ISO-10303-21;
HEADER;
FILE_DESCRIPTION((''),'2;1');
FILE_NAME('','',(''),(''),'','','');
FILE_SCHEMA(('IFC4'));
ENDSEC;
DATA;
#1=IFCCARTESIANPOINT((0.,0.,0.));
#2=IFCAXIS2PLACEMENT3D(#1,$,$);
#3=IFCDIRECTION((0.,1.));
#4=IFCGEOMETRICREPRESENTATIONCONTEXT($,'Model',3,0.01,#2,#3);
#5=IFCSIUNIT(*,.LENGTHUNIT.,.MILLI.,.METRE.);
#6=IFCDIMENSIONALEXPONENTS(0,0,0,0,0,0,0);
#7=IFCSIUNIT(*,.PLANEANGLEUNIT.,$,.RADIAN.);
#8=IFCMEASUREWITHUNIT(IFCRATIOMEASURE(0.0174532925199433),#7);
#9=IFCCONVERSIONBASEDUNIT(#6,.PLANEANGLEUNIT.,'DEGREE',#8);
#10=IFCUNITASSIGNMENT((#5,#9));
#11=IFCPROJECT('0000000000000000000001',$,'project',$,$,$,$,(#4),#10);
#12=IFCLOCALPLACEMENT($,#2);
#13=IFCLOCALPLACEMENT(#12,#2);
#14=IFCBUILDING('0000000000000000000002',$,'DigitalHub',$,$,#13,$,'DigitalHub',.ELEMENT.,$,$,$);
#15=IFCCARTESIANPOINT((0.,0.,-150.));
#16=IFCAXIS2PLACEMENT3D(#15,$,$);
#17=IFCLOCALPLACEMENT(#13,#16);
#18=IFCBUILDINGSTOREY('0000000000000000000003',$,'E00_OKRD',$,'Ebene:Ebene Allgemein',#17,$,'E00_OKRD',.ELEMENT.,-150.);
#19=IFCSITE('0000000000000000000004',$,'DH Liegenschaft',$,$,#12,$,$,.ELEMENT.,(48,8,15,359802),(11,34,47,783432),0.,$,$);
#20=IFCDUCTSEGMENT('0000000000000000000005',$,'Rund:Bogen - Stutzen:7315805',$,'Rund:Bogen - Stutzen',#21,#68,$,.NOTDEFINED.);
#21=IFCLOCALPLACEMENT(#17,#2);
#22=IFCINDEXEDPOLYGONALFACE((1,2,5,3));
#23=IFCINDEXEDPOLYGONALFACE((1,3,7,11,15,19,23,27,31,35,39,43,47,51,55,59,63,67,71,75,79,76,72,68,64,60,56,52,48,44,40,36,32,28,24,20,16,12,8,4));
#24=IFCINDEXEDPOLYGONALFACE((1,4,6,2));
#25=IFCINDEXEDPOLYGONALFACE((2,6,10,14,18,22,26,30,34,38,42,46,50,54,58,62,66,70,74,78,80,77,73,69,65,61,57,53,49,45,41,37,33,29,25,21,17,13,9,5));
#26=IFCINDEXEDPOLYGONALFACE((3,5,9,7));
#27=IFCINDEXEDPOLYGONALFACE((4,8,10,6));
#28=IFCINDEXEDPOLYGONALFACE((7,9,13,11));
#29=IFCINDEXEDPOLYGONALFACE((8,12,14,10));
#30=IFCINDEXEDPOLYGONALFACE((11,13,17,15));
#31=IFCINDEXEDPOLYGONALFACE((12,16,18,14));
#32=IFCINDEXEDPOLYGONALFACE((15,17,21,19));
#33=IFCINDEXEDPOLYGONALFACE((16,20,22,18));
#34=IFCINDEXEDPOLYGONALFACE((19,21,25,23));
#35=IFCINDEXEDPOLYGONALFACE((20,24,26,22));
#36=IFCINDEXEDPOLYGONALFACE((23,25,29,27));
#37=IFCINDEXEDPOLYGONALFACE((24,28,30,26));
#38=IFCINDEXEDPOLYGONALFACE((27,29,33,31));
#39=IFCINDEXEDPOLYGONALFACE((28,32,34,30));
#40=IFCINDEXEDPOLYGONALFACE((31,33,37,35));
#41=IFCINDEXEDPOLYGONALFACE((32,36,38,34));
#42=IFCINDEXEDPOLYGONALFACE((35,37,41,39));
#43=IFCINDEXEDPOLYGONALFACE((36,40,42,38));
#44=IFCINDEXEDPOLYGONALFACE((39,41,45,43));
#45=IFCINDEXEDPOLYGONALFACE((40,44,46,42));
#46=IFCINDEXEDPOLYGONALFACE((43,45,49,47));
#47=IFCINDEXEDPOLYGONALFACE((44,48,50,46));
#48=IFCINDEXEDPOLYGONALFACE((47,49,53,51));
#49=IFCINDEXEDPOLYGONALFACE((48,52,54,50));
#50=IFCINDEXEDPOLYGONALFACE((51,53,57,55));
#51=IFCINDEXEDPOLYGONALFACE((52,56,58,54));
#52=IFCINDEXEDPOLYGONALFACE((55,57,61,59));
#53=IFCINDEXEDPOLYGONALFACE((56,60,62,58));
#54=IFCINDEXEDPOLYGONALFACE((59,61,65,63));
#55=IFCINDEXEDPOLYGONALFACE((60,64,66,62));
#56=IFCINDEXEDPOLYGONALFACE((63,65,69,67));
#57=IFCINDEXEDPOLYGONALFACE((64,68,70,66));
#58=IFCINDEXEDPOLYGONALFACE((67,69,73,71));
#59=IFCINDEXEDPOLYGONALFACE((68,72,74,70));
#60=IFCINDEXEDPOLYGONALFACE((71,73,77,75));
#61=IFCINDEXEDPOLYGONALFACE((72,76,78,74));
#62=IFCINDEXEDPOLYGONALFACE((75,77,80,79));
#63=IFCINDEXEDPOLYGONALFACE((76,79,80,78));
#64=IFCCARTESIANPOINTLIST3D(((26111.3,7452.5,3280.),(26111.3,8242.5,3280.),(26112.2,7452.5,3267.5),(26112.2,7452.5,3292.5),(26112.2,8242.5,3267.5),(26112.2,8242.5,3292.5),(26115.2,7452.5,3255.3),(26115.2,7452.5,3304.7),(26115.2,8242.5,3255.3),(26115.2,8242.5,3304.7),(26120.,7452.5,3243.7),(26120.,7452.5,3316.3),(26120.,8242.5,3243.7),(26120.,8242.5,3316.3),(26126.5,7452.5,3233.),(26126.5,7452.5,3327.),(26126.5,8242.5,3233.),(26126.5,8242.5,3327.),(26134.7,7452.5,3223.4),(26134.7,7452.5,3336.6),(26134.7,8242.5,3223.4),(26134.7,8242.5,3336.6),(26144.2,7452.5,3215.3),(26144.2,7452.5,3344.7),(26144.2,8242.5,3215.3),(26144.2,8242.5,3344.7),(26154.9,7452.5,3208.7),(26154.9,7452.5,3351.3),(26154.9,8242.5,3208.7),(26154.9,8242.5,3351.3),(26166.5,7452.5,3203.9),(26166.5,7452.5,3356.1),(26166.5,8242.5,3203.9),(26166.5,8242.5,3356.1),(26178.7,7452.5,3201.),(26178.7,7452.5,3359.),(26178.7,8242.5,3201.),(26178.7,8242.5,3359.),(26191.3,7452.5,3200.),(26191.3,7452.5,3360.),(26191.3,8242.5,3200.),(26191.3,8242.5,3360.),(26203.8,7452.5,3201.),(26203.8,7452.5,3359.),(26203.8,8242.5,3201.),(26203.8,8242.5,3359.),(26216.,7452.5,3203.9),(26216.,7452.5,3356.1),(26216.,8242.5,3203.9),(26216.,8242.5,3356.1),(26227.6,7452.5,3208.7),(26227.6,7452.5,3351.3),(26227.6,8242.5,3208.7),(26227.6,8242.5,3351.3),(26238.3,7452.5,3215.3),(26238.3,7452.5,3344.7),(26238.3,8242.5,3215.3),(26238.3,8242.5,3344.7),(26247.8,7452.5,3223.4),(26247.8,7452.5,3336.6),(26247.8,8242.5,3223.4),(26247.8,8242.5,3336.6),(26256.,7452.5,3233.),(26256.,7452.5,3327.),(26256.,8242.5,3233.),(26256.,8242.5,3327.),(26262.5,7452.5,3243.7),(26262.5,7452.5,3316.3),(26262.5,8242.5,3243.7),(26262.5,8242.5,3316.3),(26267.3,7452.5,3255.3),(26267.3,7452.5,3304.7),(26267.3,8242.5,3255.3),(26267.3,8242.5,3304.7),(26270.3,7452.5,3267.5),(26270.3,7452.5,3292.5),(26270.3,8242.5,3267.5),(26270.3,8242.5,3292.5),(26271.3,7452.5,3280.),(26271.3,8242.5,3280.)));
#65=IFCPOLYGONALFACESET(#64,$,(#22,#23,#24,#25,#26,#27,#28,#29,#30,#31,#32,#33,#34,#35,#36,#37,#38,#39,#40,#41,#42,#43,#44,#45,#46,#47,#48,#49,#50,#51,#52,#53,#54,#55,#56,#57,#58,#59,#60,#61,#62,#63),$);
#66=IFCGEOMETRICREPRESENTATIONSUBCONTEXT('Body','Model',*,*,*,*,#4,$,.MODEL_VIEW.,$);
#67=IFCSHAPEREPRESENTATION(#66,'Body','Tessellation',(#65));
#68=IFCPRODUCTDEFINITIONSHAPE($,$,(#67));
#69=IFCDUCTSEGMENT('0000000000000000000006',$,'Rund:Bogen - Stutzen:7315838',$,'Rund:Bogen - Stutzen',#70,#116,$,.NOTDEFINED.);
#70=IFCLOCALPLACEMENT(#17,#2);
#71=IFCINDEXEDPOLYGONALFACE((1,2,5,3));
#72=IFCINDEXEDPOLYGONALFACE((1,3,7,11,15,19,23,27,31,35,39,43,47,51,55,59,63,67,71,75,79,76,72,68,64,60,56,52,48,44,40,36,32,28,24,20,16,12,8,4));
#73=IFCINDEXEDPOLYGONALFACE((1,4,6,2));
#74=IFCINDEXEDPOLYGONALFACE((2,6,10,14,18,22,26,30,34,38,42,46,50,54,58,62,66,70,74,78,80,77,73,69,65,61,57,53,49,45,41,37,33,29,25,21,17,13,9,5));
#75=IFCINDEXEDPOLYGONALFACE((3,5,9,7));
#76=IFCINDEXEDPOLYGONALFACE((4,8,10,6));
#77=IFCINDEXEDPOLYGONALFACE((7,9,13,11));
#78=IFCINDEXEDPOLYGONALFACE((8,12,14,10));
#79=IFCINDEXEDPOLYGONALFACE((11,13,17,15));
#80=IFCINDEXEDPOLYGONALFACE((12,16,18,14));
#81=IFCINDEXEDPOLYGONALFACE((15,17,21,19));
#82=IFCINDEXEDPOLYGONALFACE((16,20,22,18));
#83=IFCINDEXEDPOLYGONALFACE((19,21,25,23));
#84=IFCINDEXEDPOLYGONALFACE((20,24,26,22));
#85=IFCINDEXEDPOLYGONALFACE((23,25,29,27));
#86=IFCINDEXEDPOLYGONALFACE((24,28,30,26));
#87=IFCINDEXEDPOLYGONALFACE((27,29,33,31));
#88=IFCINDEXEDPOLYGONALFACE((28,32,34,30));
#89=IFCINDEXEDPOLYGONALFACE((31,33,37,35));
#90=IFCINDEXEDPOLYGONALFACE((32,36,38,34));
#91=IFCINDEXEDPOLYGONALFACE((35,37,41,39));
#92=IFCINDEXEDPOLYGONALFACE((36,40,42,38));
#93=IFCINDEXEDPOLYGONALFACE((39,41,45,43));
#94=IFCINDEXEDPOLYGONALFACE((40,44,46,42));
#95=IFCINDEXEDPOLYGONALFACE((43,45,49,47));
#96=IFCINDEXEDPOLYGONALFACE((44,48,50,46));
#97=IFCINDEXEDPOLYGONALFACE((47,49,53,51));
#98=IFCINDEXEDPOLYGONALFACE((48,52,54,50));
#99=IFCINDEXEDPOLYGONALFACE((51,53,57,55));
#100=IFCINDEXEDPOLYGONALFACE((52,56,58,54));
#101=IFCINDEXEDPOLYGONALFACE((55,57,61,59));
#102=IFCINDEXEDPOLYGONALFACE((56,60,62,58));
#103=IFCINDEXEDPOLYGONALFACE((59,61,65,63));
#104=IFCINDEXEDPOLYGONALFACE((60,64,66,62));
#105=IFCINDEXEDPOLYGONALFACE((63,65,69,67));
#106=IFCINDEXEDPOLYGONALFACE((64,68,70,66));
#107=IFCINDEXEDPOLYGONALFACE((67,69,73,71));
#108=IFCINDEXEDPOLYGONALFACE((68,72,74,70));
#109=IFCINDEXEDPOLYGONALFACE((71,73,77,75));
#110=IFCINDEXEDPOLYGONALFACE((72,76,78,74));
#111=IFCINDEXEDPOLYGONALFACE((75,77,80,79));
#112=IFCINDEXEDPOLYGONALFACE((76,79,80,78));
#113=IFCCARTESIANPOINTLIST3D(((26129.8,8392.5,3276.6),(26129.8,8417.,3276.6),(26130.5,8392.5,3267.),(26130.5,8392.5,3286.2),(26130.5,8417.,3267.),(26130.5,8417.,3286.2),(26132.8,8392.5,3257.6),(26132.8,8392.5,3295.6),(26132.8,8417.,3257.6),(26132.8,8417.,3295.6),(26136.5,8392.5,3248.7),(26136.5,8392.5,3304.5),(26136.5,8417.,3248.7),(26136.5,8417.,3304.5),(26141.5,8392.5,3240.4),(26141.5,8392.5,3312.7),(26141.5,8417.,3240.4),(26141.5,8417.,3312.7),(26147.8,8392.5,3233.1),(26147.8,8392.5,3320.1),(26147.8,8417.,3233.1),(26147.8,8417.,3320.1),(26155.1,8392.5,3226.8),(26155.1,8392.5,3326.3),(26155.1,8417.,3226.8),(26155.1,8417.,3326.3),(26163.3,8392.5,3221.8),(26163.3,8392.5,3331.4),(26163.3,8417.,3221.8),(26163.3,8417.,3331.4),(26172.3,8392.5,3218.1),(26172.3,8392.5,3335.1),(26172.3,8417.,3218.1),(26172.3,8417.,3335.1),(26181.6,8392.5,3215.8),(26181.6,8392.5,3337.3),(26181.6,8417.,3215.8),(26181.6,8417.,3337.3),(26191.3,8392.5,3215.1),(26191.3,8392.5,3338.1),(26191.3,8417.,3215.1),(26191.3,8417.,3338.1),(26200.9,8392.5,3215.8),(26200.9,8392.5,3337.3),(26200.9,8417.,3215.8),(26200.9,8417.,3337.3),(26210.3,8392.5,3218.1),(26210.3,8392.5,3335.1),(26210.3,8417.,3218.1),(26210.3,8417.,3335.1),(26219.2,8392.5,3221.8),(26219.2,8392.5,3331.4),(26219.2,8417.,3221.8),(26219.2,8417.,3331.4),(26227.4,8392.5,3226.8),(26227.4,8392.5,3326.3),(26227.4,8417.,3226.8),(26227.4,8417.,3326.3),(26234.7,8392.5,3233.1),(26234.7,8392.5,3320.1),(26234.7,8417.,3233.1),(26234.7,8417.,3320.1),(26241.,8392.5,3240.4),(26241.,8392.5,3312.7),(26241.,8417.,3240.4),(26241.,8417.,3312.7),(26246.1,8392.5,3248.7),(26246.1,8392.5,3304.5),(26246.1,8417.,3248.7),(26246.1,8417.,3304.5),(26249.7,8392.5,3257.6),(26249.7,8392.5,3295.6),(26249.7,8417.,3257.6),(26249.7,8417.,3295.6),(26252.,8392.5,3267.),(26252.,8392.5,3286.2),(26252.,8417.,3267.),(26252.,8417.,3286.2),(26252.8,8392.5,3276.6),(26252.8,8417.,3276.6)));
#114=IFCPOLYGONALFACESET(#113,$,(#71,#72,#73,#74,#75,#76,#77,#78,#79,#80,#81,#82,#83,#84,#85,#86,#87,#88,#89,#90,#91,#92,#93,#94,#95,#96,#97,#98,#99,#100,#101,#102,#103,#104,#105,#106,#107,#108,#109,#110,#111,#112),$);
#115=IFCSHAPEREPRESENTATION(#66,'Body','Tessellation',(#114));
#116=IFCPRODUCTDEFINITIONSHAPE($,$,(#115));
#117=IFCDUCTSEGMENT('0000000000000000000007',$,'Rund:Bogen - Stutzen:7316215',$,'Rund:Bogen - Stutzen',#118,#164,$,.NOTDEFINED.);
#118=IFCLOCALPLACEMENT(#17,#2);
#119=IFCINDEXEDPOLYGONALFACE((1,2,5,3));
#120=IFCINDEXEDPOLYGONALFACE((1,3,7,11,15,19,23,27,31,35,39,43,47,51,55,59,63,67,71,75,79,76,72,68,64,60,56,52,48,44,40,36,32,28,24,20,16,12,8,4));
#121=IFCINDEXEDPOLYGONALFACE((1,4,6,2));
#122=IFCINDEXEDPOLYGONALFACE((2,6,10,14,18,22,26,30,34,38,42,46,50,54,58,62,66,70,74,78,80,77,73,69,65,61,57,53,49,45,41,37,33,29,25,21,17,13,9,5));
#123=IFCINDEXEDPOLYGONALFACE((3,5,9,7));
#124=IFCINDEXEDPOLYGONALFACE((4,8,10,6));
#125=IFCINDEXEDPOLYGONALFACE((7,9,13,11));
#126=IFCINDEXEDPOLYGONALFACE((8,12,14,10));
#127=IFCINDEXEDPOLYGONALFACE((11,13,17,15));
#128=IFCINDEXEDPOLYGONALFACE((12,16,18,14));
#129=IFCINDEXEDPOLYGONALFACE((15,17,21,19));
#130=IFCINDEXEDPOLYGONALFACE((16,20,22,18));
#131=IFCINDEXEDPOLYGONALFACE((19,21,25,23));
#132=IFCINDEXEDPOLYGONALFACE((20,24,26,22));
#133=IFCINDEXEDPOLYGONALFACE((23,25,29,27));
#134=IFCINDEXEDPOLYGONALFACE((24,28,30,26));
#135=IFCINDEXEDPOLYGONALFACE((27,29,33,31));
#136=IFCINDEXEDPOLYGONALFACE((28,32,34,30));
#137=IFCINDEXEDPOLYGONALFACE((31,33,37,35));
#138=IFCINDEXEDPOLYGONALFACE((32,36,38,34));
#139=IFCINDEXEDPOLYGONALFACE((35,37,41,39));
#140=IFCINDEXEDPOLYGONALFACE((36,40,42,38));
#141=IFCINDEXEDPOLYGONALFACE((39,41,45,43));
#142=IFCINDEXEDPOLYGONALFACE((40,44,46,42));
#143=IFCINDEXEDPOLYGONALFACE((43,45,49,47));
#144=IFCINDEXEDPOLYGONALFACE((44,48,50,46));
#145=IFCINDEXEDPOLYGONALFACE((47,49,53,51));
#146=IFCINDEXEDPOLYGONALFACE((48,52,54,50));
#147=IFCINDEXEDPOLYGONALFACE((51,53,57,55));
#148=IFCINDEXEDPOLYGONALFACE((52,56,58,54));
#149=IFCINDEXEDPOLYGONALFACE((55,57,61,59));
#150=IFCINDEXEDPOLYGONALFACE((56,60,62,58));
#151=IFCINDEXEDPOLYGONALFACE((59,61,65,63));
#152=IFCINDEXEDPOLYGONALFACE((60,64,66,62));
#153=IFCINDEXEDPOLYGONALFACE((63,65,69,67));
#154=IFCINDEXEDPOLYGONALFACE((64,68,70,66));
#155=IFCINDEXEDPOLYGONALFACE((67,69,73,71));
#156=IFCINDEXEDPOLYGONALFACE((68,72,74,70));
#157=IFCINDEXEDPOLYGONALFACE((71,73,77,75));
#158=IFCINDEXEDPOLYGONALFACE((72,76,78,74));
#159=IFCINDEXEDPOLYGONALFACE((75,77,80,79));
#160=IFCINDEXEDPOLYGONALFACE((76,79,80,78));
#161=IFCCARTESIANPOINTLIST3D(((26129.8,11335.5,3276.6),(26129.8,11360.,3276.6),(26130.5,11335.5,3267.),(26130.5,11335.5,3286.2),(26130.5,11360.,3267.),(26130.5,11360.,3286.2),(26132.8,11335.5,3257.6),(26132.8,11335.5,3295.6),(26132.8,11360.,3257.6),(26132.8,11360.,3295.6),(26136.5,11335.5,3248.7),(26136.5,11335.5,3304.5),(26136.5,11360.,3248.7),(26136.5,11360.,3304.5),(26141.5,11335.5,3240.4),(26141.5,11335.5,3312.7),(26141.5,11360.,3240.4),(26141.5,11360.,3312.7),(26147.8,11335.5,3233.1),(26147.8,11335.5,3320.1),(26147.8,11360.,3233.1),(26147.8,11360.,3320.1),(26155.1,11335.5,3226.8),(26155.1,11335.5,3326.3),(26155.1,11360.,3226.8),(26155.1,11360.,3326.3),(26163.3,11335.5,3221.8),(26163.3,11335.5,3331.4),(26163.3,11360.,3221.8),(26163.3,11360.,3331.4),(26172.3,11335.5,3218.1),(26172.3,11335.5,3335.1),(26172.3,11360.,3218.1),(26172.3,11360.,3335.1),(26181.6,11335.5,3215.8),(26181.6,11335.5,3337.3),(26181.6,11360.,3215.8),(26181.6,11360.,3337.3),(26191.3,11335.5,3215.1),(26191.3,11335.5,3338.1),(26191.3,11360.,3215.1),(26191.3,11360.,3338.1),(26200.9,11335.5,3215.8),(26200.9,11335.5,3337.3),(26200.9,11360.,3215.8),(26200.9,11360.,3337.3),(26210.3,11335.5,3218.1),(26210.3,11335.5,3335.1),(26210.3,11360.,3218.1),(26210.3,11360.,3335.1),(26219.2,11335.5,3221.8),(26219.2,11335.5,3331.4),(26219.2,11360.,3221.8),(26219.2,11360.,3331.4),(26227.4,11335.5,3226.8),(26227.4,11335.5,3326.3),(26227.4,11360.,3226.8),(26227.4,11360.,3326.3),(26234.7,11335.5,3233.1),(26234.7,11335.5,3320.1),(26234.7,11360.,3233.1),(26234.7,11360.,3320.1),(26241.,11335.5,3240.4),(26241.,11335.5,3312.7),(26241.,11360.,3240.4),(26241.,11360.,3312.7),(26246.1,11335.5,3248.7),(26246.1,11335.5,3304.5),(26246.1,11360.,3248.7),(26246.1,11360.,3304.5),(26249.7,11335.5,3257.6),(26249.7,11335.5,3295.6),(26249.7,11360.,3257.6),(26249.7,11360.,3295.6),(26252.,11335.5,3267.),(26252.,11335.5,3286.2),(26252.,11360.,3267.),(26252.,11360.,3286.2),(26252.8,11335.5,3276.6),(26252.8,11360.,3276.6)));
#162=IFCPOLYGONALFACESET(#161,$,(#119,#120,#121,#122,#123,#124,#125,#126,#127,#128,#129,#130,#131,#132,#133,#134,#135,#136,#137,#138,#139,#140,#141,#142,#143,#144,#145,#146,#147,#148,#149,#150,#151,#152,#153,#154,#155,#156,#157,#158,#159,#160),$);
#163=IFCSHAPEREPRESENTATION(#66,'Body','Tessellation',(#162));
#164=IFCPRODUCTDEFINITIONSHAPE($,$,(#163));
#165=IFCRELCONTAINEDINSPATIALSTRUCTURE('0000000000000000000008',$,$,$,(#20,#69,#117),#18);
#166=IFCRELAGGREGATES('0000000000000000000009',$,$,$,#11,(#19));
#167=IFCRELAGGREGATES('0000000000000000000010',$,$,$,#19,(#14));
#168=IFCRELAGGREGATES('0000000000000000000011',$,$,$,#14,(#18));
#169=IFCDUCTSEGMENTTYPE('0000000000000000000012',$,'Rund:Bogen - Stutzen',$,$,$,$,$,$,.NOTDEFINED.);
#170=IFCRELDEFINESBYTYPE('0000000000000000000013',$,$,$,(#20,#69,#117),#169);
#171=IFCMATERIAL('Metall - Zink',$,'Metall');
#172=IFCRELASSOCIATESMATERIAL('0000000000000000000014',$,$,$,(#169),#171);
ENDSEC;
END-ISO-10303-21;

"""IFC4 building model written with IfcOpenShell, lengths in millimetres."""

from ifc_helpers import new_model, entity, si_unit, converted_unit, direction, frame, origin, place, context, subcontext, project, spatial, indexed_curve, outline, extrude, material, type_object, element, save


model = new_model("IFC4")

# Units and contexts
model_context = context("Model", 3, precision=0.01, world=origin(), true_north=direction((0.0, 1.0)))
body_context = subcontext(model_context, "Body", "Model", "MODEL_VIEW")
ifc_project = project(units=[si_unit("LENGTHUNIT", "METRE", prefix="MILLI"), converted_unit("PLANEANGLEUNIT", "DEGREE", entity("IfcRatioMeasure", 0.0174532925199433), si_unit("PLANEANGLEUNIT", "RADIAN"), dimensions=[0, 0, 0, 0, 0, 0, 0])], contexts=[model_context])

# Site, building, storey
site_placement = place(None, origin())
site = spatial("IfcSite", under=ifc_project, at=site_placement, Name="DH Liegenschaft", CompositionType="ELEMENT", RefLatitude=(48, 8, 15, 359802), RefLongitude=(11, 34, 47, 783432), RefElevation=0.0)
building_placement = place(site_placement, origin())
building = spatial("IfcBuilding", under=site, at=building_placement, Name="DigitalHub", LongName="DigitalHub", CompositionType="ELEMENT")
storey_placement = place(building_placement, frame((0.0, 0.0, -150.0)))
storey = spatial("IfcBuildingStorey", under=building, at=storey_placement, Name="E00_OKRD", ObjectType="Ebene:Ebene Allgemein", LongName="E00_OKRD", CompositionType="ELEMENT", Elevation=-150.0)

# Duct segments
ifc_material_1 = material(Name="Metall - Zink", Category="Metall")
duct_segment_type_1 = type_object("IfcDuctSegmentType", Name="Rund:Bogen - Stutzen", PredefinedType="NOTDEFINED", material=ifc_material_1)
duct_segment_1_placement = place(storey_placement, frame((26109.7, 7452.5, 3198.4)))
element("IfcDuctSegment", 1, at=duct_segment_1_placement, inside=storey, type_object=duct_segment_type_1, Name="Rund:Bogen - Stutzen:7315805", ObjectType="Rund:Bogen - Stutzen", PredefinedType="NOTDEFINED", context=body_context, shape_type="SweptSolid", body=[
    extrude(outline(indexed_curve([(80.0, 0.0), (79.0, 12.5), (76.1, 24.7), (71.3, 36.3), (64.7, 47.0), (56.6, 56.6), (47.0, 64.7), (36.3, 71.3), (24.7, 76.1), (12.5, 79.0), (0.0, 80.0), (-12.5, 79.0), (-24.7, 76.1), (-36.3, 71.3), (-47.0, 64.7), (-56.6, 56.6), (-64.7, 47.0), (-71.3, 36.3), (-76.1, 24.7), (-79.0, 12.5), (-80.0, 0.0), (-79.0, -12.5), (-76.1, -24.7), (-71.3, -36.3), (-64.7, -47.0), (-56.6, -56.6), (-47.0, -64.7), (-36.3, -71.3), (-24.7, -76.1), (-12.5, -79.0), (0.0, -80.0), (12.5, -79.0), (24.7, -76.1), (36.3, -71.3), (47.0, -64.7), (56.6, -56.6), (64.7, -47.0), (71.3, -36.3), (76.1, -24.7), (79.0, -12.5), (80.0, 0.0)], self_intersect=False)), frame((81.6, 0.0, 81.6), z_axis=(0.0, 1.0, 0.0), x_axis=(-1.0, 0.0, 0.0)), (0.0, 0.0, 1.0), 789.9),
])
duct_segment_2_placement = place(storey_placement, frame((26128.2, 8392.5, 3213.5)))
element("IfcDuctSegment", 2, at=duct_segment_2_placement, inside=storey, type_object=duct_segment_type_1, Name="Rund:Bogen - Stutzen:7315838", ObjectType="Rund:Bogen - Stutzen", PredefinedType="NOTDEFINED", context=body_context, shape_type="SweptSolid", body=[
    extrude(outline(indexed_curve([(61.5, 0.0), (60.7, 9.6), (58.5, 19.0), (54.8, 27.9), (49.8, 36.1), (43.5, 43.5), (36.1, 49.8), (27.9, 54.8), (19.0, 58.5), (9.6, 60.7), (0.0, 61.5), (-9.6, 60.7), (-19.0, 58.5), (-27.9, 54.8), (-36.1, 49.8), (-43.5, 43.5), (-49.8, 36.1), (-54.8, 27.9), (-58.5, 19.0), (-60.7, 9.6), (-61.5, 0.0), (-60.7, -9.6), (-58.5, -19.0), (-54.8, -27.9), (-49.8, -36.1), (-43.5, -43.5), (-36.1, -49.8), (-27.9, -54.8), (-19.0, -58.5), (-9.6, -60.7), (0.0, -61.5), (9.6, -60.7), (19.0, -58.5), (27.9, -54.8), (36.1, -49.8), (43.5, -43.5), (49.8, -36.1), (54.8, -27.9), (58.5, -19.0), (60.7, -9.6), (61.5, 0.0)], self_intersect=False)), frame((63.1, 0.0, 63.1), z_axis=(0.0, 1.0, 0.0), x_axis=(1.0, 0.0, 0.0)), (0.0, 0.0, 1.0), 24.5),
])
duct_segment_3_placement = place(storey_placement, frame((26128.2, 11335.5, 3213.5)))
element("IfcDuctSegment", 3, at=duct_segment_3_placement, inside=storey, type_object=duct_segment_type_1, Name="Rund:Bogen - Stutzen:7316215", ObjectType="Rund:Bogen - Stutzen", PredefinedType="NOTDEFINED", context=body_context, shape_type="SweptSolid", body=[
    extrude(outline(indexed_curve([(61.5, 0.0), (60.7, 9.6), (58.5, 19.0), (54.8, 27.9), (49.8, 36.1), (43.5, 43.5), (36.1, 49.8), (27.9, 54.8), (19.0, 58.5), (9.6, 60.7), (0.0, 61.5), (-9.6, 60.7), (-19.0, 58.5), (-27.9, 54.8), (-36.1, 49.8), (-43.5, 43.5), (-49.8, 36.1), (-54.8, 27.9), (-58.5, 19.0), (-60.7, 9.6), (-61.5, 0.0), (-60.7, -9.6), (-58.5, -19.0), (-54.8, -27.9), (-49.8, -36.1), (-43.5, -43.5), (-36.1, -49.8), (-27.9, -54.8), (-19.0, -58.5), (-9.6, -60.7), (0.0, -61.5), (9.6, -60.7), (19.0, -58.5), (27.9, -54.8), (36.1, -49.8), (43.5, -43.5), (49.8, -36.1), (54.8, -27.9), (58.5, -19.0), (60.7, -9.6), (61.5, 0.0)], self_intersect=False)), frame((63.1, 0.0, 63.1), z_axis=(0.0, 1.0, 0.0), x_axis=(-1.0, 0.0, 0.0)), (0.0, 0.0, 1.0), 24.5),
])

save(model, "model.ifc")
